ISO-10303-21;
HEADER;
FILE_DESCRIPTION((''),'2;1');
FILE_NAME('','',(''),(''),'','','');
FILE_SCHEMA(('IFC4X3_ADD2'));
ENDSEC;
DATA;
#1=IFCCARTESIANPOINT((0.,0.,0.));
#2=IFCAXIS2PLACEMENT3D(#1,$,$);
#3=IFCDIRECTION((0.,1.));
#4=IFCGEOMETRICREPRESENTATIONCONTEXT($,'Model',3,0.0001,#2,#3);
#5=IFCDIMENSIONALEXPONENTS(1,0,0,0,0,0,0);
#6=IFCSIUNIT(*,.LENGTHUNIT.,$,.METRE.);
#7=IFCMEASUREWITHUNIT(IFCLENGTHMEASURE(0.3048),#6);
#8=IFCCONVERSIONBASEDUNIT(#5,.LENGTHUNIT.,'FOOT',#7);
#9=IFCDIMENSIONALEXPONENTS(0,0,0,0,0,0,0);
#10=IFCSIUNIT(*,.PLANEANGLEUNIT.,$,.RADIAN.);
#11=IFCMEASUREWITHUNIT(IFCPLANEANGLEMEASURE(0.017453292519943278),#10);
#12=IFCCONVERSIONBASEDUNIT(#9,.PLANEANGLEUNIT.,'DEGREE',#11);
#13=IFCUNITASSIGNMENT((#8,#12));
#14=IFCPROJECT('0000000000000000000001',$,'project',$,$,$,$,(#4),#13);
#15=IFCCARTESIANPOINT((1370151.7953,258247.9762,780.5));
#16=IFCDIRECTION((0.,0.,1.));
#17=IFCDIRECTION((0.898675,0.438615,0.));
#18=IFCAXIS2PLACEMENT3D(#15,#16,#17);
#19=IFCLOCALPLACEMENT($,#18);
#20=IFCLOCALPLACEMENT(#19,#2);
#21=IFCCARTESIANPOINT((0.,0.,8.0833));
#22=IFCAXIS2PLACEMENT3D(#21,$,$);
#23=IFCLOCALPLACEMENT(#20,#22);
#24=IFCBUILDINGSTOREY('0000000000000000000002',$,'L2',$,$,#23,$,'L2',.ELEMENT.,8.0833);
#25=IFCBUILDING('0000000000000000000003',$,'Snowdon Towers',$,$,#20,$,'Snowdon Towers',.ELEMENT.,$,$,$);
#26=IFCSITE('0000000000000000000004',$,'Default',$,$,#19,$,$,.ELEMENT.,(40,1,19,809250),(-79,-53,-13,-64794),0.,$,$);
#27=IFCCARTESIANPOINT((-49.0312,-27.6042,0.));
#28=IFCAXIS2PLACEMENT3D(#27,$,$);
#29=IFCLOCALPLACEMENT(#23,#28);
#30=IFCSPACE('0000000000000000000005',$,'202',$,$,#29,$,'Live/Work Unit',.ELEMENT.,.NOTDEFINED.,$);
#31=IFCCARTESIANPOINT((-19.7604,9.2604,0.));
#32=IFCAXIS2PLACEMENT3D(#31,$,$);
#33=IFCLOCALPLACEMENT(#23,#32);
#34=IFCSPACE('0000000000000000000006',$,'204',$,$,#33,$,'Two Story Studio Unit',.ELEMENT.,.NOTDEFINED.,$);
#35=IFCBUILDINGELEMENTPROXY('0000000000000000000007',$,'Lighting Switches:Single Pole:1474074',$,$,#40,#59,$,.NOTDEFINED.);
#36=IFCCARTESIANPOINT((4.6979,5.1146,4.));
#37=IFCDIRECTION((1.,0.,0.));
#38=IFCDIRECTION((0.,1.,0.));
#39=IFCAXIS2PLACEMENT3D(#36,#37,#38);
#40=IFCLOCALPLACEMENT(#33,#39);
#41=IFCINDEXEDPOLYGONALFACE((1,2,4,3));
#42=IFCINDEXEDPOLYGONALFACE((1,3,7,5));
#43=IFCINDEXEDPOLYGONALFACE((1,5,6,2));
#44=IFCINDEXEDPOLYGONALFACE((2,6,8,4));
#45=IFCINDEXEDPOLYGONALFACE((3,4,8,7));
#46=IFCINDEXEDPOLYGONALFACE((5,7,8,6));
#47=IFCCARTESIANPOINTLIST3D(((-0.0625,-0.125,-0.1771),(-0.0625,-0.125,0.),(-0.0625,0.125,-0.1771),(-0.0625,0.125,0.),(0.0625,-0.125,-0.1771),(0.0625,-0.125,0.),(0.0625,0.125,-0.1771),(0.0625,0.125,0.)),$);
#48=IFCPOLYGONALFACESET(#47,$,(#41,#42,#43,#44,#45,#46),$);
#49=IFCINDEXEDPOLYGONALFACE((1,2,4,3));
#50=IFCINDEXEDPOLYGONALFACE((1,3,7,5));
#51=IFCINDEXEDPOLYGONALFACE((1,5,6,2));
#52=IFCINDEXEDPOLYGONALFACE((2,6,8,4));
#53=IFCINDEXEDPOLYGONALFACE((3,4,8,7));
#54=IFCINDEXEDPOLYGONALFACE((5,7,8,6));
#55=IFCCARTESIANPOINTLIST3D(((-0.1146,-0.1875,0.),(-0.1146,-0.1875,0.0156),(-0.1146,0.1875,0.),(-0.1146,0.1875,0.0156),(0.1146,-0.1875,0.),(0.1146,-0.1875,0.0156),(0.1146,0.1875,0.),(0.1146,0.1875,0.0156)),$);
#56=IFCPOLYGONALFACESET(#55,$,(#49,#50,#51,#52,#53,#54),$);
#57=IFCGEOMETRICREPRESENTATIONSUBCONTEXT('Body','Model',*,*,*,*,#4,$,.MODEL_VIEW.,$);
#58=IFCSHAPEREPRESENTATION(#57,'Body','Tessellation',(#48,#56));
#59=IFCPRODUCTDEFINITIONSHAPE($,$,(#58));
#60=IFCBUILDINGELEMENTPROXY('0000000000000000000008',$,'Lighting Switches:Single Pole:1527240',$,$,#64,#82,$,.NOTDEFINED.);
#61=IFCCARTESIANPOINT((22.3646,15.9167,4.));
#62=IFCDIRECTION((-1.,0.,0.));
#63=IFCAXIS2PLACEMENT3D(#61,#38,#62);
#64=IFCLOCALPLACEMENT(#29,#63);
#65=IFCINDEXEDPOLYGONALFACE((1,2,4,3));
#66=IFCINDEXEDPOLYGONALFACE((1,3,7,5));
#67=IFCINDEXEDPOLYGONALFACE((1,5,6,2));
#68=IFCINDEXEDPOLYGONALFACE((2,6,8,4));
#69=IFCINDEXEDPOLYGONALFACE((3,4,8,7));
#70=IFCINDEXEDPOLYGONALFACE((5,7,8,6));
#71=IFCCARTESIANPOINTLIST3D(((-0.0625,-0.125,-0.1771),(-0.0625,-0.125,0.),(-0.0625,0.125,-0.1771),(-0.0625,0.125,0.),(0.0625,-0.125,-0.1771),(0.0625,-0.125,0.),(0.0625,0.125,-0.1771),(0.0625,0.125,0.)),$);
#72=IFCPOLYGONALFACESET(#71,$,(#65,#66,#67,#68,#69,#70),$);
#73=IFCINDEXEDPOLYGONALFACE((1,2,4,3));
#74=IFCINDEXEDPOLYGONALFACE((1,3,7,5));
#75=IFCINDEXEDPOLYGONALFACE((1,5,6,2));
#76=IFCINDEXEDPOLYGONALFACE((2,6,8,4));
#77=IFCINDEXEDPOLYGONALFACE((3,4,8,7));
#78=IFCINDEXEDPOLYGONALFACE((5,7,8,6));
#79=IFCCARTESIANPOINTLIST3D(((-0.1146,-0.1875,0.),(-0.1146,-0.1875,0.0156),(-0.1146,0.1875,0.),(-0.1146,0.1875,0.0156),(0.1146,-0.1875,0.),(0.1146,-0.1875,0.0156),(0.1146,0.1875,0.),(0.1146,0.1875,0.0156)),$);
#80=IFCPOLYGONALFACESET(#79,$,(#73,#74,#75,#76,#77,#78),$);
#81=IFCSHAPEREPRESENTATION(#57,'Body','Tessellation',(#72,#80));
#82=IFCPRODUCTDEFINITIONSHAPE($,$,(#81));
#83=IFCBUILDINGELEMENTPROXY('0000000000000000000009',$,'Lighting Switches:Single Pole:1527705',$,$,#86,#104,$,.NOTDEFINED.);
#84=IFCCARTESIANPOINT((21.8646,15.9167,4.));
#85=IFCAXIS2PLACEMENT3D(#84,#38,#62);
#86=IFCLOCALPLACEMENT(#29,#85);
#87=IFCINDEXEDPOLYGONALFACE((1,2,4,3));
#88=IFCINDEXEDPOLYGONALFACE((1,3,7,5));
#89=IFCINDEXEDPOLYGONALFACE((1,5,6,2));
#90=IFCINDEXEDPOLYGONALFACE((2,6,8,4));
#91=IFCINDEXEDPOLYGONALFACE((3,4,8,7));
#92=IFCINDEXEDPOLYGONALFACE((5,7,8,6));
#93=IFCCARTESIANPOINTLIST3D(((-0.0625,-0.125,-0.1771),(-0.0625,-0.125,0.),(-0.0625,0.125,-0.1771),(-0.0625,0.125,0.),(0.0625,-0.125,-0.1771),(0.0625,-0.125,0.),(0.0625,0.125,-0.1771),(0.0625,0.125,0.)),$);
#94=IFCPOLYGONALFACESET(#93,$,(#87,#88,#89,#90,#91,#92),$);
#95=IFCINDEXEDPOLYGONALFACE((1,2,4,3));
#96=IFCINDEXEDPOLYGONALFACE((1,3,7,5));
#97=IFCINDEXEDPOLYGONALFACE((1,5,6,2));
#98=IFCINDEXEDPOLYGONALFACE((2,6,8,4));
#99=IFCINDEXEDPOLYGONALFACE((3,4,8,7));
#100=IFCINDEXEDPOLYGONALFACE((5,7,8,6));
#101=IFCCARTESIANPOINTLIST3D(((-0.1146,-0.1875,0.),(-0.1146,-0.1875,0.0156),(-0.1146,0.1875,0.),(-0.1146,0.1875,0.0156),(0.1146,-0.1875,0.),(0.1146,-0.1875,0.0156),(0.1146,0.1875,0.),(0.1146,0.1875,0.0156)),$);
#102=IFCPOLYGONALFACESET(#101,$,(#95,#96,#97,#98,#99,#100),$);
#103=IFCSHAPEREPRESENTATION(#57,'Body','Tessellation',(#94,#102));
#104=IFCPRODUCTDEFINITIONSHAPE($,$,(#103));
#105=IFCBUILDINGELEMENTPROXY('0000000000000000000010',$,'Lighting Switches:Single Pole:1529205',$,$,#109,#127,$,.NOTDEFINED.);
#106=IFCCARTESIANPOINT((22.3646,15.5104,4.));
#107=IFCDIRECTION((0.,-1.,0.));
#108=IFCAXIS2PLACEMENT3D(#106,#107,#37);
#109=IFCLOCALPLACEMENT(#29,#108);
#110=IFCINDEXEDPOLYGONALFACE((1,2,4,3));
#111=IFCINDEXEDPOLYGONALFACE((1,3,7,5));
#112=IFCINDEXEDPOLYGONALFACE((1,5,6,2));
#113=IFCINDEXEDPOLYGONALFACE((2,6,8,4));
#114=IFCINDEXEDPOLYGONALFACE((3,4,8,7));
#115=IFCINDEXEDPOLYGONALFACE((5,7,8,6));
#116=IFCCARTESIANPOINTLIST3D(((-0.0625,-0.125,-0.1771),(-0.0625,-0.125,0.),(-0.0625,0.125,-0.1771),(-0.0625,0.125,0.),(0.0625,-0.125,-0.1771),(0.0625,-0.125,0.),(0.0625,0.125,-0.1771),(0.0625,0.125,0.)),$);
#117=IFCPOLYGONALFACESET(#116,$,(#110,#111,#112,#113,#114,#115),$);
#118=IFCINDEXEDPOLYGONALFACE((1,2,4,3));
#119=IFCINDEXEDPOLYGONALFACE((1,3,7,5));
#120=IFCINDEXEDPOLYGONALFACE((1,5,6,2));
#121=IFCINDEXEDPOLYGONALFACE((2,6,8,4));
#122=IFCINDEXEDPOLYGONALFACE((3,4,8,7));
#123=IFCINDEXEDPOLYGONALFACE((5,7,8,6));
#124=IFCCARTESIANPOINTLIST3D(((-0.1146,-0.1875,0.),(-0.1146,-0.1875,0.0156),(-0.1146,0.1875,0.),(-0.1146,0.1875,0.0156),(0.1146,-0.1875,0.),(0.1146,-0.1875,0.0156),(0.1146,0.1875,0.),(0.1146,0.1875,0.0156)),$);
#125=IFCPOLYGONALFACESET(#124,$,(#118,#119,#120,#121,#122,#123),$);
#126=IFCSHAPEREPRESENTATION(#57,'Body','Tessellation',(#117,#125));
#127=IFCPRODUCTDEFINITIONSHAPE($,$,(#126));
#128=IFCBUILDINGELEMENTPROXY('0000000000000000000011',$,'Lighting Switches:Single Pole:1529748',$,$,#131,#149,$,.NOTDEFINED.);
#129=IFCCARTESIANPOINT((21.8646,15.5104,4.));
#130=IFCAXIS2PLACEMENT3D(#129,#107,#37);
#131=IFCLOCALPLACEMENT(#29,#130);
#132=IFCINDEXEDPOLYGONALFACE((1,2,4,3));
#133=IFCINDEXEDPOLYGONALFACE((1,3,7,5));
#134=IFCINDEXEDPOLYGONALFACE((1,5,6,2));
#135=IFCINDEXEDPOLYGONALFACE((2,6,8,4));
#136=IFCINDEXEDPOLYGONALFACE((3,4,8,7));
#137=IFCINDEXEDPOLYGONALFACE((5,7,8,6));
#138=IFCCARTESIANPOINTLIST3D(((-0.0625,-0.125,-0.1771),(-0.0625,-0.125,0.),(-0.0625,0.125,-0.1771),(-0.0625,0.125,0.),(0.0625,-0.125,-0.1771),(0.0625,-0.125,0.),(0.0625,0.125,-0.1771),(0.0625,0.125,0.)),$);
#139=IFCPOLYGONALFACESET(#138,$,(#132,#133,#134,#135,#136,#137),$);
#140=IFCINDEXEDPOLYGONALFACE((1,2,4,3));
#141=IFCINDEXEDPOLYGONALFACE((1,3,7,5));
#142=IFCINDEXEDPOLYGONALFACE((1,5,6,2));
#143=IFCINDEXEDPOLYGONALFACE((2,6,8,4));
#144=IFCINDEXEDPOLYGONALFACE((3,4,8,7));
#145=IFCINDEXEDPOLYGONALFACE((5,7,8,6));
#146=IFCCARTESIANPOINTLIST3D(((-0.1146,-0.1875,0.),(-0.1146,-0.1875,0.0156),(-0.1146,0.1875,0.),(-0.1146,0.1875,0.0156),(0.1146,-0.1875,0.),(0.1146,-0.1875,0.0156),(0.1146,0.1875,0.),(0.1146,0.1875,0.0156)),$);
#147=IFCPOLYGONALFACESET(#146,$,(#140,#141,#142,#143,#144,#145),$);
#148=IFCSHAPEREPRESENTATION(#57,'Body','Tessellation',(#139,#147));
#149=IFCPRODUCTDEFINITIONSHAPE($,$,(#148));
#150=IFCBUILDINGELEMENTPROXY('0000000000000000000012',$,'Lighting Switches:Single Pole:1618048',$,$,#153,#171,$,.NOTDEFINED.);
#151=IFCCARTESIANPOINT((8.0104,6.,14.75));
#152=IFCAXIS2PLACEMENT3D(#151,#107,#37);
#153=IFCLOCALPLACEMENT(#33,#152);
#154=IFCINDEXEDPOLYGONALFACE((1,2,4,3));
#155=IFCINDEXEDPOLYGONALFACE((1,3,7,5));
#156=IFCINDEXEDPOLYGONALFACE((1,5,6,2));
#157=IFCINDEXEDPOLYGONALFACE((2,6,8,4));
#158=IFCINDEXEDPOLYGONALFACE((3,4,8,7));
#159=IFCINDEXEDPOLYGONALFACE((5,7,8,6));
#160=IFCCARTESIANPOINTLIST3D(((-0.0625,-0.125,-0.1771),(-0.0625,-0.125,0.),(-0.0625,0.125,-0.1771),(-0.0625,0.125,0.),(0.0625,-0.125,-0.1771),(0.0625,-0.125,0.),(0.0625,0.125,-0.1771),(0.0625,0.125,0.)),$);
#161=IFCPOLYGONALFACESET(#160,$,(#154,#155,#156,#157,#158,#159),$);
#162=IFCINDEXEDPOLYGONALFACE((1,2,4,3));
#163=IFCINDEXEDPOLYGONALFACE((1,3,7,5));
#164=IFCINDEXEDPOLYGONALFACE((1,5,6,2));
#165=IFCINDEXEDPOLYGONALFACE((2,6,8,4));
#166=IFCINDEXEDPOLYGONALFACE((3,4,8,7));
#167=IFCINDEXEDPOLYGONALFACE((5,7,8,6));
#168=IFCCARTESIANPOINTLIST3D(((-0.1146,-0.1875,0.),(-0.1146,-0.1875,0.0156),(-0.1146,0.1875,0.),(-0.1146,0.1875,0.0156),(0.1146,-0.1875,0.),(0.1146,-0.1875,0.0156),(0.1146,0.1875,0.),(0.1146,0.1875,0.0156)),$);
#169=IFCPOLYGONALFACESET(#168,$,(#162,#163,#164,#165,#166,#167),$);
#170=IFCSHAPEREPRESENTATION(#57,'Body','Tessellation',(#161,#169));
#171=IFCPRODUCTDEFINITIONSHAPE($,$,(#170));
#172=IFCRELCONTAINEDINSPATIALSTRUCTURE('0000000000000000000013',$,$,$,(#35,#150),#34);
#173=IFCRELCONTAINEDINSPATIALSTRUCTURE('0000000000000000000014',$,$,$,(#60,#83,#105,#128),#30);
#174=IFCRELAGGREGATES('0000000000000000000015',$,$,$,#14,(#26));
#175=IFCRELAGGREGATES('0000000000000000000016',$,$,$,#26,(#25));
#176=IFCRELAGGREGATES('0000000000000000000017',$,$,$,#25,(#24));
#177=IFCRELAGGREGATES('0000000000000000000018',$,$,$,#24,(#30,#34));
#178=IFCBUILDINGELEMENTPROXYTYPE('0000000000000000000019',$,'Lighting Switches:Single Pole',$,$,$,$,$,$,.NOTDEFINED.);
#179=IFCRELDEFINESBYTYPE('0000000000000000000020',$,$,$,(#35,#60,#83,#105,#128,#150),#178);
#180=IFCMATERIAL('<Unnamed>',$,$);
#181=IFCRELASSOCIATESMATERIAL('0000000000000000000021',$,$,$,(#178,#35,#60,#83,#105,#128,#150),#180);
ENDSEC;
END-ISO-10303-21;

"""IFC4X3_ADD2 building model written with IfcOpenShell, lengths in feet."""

from ifc_helpers import new_model, entity, si_unit, converted_unit, direction, frame, frame_2d, origin, origin_2d_with_axis, place, context, subcontext, project, spatial, rectangle, extrude, source, transform, mapped, material, type_object, type_shapes, element, save


model = new_model("IFC4X3_ADD2")

# Units and contexts
model_context = context("Model", 3, precision=0.0001, world=origin(), true_north=direction((0.0, 1.0)))
body_context = subcontext(model_context, "Body", "Model", "MODEL_VIEW")
ifc_project = project(units=[converted_unit("LENGTHUNIT", "FOOT", entity("IfcLengthMeasure", 0.3048), si_unit("LENGTHUNIT", "METRE"), dimensions=[1, 0, 0, 0, 0, 0, 0]), converted_unit("PLANEANGLEUNIT", "DEGREE", entity("IfcPlaneAngleMeasure", 0.017453292519943278), si_unit("PLANEANGLEUNIT", "RADIAN"), dimensions=[0, 0, 0, 0, 0, 0, 0])], contexts=[model_context])

# Site, building, storey, space
site_placement = place(None, frame((1370151.7953, 258247.9762, 780.5), z_axis=(0.0, 0.0, 1.0), x_axis=(0.898675, 0.438615, 0.0)))
site = spatial("IfcSite", under=ifc_project, at=site_placement, Name="Default", CompositionType="ELEMENT", RefLatitude=(40, 1, 19, 809250), RefLongitude=(-79, -53, -13, -64794), RefElevation=0.0)
building_placement = place(site_placement, origin())
building = spatial("IfcBuilding", under=site, at=building_placement, Name="Snowdon Towers", LongName="Snowdon Towers", CompositionType="ELEMENT")
storey_placement = place(building_placement, frame((0.0, 0.0, 8.0833)))
storey = spatial("IfcBuildingStorey", under=building, at=storey_placement, Name="L2", LongName="L2", CompositionType="ELEMENT", Elevation=8.0833)
space_1_placement = place(storey_placement, frame((-49.0312, -27.6042, 0.0)))
space_1 = spatial("IfcSpace", under=storey, at=space_1_placement, Name="202", LongName="Live/Work Unit", CompositionType="ELEMENT", PredefinedType="NOTDEFINED")

# Shared definitions
ifc_material_1 = material(Name="<Unnamed>")

# Shared definitions
space_2_placement = place(storey_placement, frame((-19.7604, 9.2604, 0.0)))
space_2 = spatial("IfcSpace", under=storey, at=space_2_placement, Name="204", LongName="Two Story Studio Unit", CompositionType="ELEMENT", PredefinedType="NOTDEFINED")

# Building element proxies
building_element_proxy_type_1 = type_object("IfcBuildingElementProxyType", Name="Lighting Switches:Single Pole", PredefinedType="NOTDEFINED", material=ifc_material_1)
shared_shape_1 = source(origin(), body_context, "Body", "SweptSolid", [
    extrude(rectangle(XDim=0.125, YDim=0.25, at=origin_2d_with_axis()), frame((0.0, 0.0, -0.1771), z_axis=(0.0, 0.0, 1.0), x_axis=(-1.0, 0.0, 0.0)), (0.0, 0.0, 1.0), 0.1771),
    extrude(rectangle(XDim=0.2292, YDim=0.375, at=frame_2d((0.0, 0.0), x_axis=(1.0, 0.0))), frame((0.0, 0.0, 0.0), z_axis=(0.0, 0.0, 1.0), x_axis=(-1.0, 0.0, 0.0)), (0.0, 0.0, 1.0), 0.0156),
])
type_shapes(building_element_proxy_type_1, [shared_shape_1])
proxy_1_placement = place(space_2_placement, frame((4.6979, 5.1146, 4.0), z_axis=(1.0, 0.0, 0.0), x_axis=(0.0, 1.0, 0.0)))
element("IfcBuildingElementProxy", 1, at=proxy_1_placement, inside=space_2, type_object=building_element_proxy_type_1, material=ifc_material_1, Name="Lighting Switches:Single Pole:1474074", PredefinedType="NOTDEFINED", context=body_context, shape_type="MappedRepresentation", body=[
    mapped(shared_shape_1, transform((0.0, 0.0, 0.0), scale=1.0)),
])
for number, where, z_axis, x_axis, name in (
    (2, (22.3646, 15.9167, 4.0), (0.0, 1.0, 0.0), (-1.0, 0.0, 0.0), "Lighting Switches:Single Pole:1527240"),
    (3, (21.8646, 15.9167, 4.0), (0.0, 1.0, 0.0), (-1.0, 0.0, 0.0), "Lighting Switches:Single Pole:1527705"),
    (4, (22.3646, 15.5104, 4.0), (0.0, -1.0, 0.0), (1.0, 0.0, 0.0), "Lighting Switches:Single Pole:1529205"),
    (5, (21.8646, 15.5104, 4.0), (0.0, -1.0, 0.0), (1.0, 0.0, 0.0), "Lighting Switches:Single Pole:1529748"),
):
    element("IfcBuildingElementProxy", number, at=place(space_1_placement, frame(where, z_axis=z_axis, x_axis=x_axis)), inside=space_1, type_object=building_element_proxy_type_1, material=ifc_material_1, Name=name, PredefinedType="NOTDEFINED", context=body_context, shape_type="MappedRepresentation", body=[
        mapped(shared_shape_1, transform((0.0, 0.0, 0.0), scale=1.0)),
    ])
proxy_2_placement = place(space_2_placement, frame((8.0104, 6.0, 14.75), z_axis=(0.0, -1.0, 0.0), x_axis=(1.0, 0.0, 0.0)))
element("IfcBuildingElementProxy", 6, at=proxy_2_placement, inside=space_2, type_object=building_element_proxy_type_1, material=ifc_material_1, Name="Lighting Switches:Single Pole:1618048", PredefinedType="NOTDEFINED", context=body_context, shape_type="MappedRepresentation", body=[
    mapped(shared_shape_1, transform((0.0, 0.0, 0.0), scale=1.0)),
])

save(model, "model.ifc")
